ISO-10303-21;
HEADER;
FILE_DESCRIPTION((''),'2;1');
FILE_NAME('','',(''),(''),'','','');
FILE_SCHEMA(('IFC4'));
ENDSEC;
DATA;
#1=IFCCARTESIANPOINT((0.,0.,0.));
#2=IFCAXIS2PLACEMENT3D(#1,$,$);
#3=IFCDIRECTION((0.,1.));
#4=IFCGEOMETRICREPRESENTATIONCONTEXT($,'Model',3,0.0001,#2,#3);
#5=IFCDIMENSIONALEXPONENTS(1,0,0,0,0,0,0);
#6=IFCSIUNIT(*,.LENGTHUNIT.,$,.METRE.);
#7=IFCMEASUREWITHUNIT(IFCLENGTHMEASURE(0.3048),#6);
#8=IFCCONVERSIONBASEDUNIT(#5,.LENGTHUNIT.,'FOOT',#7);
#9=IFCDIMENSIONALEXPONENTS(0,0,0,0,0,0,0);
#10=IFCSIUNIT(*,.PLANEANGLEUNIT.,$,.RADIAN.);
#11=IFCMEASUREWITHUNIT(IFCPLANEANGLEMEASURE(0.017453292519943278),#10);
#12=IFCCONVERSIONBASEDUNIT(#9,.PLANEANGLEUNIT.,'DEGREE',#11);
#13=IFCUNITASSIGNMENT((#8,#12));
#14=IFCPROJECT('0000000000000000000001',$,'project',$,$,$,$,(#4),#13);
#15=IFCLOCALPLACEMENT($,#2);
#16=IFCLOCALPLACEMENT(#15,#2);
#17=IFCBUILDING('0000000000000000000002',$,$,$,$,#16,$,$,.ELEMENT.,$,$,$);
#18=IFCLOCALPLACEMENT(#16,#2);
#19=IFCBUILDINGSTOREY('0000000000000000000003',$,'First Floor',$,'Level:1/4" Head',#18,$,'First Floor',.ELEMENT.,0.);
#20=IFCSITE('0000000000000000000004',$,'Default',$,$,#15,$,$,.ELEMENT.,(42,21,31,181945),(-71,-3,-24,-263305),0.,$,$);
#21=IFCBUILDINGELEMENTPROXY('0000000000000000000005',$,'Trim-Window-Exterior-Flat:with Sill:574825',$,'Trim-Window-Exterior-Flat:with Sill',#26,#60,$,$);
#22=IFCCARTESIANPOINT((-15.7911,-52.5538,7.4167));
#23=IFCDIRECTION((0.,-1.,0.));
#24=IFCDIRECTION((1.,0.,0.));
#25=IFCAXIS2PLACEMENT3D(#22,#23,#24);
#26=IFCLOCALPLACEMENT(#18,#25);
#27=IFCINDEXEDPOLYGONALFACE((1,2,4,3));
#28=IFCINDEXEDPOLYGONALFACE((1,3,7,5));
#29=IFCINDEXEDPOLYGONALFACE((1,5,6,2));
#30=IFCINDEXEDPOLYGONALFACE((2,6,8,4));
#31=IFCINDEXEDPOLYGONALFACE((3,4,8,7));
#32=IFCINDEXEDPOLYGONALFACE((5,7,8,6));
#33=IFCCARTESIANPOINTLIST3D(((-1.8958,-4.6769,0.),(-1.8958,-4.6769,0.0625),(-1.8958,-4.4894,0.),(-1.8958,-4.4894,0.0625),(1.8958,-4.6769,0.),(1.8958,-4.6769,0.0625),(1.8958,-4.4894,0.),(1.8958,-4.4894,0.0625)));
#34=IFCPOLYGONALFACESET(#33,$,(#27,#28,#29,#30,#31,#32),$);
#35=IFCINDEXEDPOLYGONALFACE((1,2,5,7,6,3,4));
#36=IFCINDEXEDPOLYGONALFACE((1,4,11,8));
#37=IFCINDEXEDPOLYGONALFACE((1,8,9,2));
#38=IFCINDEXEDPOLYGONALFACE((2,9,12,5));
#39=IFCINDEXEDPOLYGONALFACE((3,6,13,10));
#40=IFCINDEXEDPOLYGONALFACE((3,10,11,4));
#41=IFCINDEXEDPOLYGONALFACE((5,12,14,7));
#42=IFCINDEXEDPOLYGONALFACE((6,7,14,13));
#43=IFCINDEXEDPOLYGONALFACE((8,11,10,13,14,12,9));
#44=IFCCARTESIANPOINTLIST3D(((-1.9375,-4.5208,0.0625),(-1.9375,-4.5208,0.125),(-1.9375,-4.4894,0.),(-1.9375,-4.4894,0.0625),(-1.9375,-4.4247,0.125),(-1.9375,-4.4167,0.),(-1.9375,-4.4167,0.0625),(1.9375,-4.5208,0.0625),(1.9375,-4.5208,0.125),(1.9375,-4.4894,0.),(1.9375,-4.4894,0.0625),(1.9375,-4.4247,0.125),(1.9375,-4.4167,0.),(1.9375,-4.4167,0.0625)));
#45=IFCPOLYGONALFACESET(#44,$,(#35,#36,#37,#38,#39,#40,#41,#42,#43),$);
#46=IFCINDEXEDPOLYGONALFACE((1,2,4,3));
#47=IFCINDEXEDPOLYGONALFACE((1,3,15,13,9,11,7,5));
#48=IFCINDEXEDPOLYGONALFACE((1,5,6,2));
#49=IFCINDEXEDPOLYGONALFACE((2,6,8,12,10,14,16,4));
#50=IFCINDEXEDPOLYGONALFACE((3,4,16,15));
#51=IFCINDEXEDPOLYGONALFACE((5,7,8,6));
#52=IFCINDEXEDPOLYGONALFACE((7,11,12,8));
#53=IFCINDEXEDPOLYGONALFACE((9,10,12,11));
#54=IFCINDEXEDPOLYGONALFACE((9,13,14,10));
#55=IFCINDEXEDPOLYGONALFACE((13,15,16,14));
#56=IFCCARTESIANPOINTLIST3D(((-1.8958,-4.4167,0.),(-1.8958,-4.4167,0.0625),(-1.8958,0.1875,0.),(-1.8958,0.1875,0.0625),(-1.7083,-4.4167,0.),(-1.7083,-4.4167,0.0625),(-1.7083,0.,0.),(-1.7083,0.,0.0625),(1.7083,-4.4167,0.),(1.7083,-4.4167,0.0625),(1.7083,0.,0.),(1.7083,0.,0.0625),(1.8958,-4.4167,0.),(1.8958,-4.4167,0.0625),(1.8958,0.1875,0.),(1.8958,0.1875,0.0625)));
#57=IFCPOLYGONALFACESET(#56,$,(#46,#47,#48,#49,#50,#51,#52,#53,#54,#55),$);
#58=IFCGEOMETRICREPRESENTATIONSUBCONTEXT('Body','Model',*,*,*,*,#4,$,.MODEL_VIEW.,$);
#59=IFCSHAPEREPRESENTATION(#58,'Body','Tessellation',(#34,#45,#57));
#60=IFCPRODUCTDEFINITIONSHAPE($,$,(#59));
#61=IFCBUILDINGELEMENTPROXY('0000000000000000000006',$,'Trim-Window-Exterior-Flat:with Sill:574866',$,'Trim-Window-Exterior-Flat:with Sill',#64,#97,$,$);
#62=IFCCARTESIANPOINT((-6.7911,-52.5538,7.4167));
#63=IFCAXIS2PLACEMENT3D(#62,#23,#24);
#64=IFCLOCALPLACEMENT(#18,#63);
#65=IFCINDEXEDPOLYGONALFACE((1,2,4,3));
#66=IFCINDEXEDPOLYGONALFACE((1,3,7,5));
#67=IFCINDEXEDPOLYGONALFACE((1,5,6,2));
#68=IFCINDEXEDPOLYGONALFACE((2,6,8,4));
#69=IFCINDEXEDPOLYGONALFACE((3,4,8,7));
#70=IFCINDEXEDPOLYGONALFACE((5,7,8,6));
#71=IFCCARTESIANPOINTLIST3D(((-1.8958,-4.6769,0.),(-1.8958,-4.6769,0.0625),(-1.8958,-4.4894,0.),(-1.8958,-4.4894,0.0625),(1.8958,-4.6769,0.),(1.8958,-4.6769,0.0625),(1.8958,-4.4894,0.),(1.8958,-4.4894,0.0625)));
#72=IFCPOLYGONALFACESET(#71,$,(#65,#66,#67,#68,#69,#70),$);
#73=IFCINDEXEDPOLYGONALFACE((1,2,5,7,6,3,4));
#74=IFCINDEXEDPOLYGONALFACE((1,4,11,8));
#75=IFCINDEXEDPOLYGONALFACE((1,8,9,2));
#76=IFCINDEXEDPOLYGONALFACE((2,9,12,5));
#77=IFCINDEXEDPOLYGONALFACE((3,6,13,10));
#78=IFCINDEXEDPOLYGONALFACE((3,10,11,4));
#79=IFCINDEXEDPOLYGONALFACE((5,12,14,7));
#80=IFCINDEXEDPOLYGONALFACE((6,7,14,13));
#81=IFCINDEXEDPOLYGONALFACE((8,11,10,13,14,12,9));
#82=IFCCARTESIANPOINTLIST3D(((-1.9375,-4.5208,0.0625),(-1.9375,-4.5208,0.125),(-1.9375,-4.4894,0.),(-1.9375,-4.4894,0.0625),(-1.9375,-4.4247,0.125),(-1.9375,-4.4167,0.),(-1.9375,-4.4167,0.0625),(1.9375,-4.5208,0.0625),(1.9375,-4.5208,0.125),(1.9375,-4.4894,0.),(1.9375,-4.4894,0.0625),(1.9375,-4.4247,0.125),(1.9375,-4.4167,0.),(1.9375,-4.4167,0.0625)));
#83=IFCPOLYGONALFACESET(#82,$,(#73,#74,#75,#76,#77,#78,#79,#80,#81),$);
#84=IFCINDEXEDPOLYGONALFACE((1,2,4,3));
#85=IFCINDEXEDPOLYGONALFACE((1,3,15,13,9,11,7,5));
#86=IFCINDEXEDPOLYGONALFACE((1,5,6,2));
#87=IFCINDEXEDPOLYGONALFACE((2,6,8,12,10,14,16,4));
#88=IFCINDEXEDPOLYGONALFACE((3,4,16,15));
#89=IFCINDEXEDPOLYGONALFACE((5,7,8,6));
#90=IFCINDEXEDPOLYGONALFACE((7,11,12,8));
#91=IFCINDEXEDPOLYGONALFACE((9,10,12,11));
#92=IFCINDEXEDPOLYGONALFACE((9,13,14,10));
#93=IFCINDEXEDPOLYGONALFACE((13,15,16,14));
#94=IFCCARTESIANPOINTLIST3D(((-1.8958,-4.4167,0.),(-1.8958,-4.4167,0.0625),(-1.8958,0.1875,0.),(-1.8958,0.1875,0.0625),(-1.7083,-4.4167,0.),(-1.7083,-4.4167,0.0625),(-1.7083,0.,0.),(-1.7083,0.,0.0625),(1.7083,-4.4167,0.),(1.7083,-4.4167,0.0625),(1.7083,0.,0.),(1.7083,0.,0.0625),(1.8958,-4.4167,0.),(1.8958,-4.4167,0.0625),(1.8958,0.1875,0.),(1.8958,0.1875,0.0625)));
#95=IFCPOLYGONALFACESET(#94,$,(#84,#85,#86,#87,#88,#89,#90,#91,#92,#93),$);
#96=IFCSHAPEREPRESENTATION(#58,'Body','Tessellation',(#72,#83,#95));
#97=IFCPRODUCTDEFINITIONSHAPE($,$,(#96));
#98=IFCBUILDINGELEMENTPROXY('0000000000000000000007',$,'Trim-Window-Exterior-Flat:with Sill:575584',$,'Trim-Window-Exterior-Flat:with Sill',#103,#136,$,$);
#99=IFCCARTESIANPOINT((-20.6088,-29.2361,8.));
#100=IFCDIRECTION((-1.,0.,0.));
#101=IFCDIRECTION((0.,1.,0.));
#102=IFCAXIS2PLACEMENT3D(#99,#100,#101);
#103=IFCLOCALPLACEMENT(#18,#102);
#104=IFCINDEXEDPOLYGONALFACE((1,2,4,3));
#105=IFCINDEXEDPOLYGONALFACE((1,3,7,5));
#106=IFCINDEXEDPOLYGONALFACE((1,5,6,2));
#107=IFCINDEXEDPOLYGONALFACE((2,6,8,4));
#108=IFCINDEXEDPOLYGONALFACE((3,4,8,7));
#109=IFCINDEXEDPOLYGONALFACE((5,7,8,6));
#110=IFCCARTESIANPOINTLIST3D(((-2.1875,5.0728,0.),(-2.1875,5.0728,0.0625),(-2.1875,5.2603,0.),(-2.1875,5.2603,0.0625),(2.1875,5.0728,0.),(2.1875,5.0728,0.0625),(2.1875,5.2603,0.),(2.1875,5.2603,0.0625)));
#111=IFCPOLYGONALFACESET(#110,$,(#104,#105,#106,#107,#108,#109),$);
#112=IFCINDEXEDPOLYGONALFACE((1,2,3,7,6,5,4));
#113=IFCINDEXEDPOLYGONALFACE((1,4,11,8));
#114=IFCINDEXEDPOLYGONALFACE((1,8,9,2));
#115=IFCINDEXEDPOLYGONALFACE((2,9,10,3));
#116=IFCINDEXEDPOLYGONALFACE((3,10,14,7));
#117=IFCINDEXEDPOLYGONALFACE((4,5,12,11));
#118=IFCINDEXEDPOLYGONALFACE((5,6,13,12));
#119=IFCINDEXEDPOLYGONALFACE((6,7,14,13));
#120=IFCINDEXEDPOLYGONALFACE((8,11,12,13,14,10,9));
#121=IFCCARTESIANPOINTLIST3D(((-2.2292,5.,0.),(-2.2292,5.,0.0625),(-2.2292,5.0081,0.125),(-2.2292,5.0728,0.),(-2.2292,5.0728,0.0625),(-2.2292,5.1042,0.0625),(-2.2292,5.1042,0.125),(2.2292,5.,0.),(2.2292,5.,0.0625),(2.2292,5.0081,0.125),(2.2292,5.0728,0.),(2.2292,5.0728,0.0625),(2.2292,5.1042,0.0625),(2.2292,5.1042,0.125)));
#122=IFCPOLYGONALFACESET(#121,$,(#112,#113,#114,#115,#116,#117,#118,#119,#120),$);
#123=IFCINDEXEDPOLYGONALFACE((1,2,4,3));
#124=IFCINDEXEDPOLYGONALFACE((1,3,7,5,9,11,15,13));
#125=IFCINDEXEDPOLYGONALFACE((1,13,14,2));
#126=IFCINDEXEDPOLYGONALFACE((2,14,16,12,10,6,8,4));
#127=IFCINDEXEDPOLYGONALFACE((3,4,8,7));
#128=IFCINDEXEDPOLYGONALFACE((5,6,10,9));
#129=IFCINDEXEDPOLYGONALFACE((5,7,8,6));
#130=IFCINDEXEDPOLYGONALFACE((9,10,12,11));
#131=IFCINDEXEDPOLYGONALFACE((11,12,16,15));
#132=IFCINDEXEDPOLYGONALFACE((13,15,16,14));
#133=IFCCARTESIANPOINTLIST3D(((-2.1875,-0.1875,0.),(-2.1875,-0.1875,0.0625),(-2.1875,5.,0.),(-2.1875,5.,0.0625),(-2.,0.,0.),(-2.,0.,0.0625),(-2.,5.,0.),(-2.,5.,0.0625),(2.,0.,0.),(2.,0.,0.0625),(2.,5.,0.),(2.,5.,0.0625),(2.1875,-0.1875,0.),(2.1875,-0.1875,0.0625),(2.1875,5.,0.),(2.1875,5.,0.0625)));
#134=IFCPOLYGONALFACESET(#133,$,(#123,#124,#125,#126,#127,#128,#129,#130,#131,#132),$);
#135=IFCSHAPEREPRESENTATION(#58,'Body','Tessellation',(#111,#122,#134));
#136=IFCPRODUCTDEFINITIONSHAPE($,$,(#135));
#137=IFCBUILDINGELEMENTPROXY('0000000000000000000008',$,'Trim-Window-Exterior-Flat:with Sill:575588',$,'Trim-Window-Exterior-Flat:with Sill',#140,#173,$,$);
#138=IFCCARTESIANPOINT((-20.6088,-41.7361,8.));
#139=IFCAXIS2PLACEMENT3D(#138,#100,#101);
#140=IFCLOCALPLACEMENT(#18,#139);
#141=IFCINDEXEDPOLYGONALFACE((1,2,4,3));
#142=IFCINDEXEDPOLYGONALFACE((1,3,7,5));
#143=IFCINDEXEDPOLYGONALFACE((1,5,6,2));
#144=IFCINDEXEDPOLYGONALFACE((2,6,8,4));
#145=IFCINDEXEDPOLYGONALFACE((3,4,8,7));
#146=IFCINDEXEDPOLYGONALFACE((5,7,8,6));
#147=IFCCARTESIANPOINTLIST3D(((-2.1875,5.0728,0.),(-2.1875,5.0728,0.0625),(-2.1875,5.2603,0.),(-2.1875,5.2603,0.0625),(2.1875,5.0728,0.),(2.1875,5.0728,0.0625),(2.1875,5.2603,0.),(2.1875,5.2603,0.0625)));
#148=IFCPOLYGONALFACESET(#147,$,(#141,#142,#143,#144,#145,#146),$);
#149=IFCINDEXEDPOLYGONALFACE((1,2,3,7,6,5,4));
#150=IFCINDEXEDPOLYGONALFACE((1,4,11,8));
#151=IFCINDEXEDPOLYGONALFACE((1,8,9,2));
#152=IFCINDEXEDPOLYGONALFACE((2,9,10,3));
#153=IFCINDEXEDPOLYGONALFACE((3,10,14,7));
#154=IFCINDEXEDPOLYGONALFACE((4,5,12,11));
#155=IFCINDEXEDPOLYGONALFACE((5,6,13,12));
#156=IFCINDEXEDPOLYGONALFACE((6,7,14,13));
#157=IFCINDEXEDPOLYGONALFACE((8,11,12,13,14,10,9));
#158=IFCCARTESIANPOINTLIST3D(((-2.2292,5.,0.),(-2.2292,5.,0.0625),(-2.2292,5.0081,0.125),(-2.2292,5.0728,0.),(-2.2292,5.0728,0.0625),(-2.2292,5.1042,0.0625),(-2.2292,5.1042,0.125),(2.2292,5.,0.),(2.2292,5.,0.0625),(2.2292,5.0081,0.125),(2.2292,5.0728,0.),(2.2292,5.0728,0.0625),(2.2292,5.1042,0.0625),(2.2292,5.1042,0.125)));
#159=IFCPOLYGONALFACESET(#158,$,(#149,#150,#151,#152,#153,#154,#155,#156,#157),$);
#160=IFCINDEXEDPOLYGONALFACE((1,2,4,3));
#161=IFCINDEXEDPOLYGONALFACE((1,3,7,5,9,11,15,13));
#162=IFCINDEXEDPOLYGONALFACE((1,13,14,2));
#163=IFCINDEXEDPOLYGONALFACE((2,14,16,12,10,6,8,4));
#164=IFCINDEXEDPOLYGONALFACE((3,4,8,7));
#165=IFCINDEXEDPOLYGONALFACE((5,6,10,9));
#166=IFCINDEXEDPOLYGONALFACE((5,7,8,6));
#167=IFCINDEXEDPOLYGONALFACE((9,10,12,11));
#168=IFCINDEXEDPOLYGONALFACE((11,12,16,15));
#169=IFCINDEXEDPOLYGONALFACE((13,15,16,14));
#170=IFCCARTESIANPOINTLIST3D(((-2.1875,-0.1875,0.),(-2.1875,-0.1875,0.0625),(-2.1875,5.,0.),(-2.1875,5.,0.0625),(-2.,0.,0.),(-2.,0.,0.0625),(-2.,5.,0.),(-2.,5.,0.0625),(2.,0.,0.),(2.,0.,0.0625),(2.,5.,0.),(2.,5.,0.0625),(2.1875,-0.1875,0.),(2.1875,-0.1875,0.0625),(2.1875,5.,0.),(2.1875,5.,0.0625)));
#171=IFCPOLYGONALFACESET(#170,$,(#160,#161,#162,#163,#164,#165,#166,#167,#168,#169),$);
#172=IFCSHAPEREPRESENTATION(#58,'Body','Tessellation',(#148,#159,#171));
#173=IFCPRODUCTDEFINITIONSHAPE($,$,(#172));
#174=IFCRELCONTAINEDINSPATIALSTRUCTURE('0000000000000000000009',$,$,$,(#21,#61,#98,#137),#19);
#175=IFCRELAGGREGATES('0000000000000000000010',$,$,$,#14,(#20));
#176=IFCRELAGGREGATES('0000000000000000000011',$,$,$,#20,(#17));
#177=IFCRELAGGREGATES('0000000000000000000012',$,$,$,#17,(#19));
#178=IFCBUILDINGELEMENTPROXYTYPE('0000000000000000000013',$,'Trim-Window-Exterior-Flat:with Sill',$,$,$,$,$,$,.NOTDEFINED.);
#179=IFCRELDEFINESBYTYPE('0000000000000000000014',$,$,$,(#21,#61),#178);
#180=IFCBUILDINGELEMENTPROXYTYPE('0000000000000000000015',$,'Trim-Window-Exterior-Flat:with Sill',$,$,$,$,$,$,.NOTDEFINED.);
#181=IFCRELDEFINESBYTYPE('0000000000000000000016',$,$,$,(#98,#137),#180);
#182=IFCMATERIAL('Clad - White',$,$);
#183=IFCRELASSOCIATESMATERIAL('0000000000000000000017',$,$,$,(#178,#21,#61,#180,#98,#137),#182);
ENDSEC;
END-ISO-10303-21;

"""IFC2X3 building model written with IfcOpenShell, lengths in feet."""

from ifc_helpers import new_model, entity, si_unit, converted_unit, direction, frame, frame_2d, origin, place, context, subcontext, project, spatial, polyline, rectangle, outline, extrude, source, transform, mapped, material, type_object, type_shapes, element, save


model = new_model("IFC2X3")

# Units and contexts
model_context = context("Model", 3, precision=0.0001, world=origin(), true_north=direction((0.0, 1.0)))
body_context = subcontext(model_context, "Body", "Model", "MODEL_VIEW")
ifc_project = project(units=[converted_unit("LENGTHUNIT", "FOOT", entity("IfcLengthMeasure", 0.3048), si_unit("LENGTHUNIT", "METRE"), dimensions=[1, 0, 0, 0, 0, 0, 0]), converted_unit("PLANEANGLEUNIT", "DEGREE", entity("IfcPlaneAngleMeasure", 0.017453292519943278), si_unit("PLANEANGLEUNIT", "RADIAN"), dimensions=[0, 0, 0, 0, 0, 0, 0])], contexts=[model_context])

# Site, building, storey
site_placement = place(None, origin())
site = spatial("IfcSite", under=ifc_project, at=site_placement, Name="Default", CompositionType="ELEMENT", RefLatitude=(42, 21, 31, 181945), RefLongitude=(-71, -3, -24, -263305), RefElevation=0.0)
building_placement = place(site_placement, origin())
building = spatial("IfcBuilding", under=site, at=building_placement, CompositionType="ELEMENT")
storey_placement = place(building_placement, origin())
storey = spatial("IfcBuildingStorey", under=building, at=storey_placement, Name="First Floor", ObjectType="Level:1/4\" Head", LongName="First Floor", CompositionType="ELEMENT", Elevation=0.0)

# Building element proxies
ifc_material_1 = material(Name="Clad - White")
building_element_proxy_type_1 = type_object("IfcBuildingElementProxyType", Name="Trim-Window-Exterior-Flat:with Sill", PredefinedType="NOTDEFINED", material=ifc_material_1)
shared_shape_1 = source(origin(), body_context, "Body", "SweptSolid", [
    extrude(rectangle(XDim=3.7917, YDim=0.1875, at=frame_2d((0.0, 0.0), x_axis=(1.0, 0.0))), frame((0.0, -4.5832, 0.0), z_axis=(0.0, 0.0, 1.0), x_axis=(-1.0, 0.0, 0.0)), (0.0, 0.0, 1.0), 0.0625),
    extrude(outline(polyline([(-0.0625, -0.0525), (0.0, -0.0525), (0.0, -0.0211), (0.0625, -0.0211), (0.0625, 0.0517), (0.0, 0.0517), (-0.0625, 0.0436), (-0.0625, -0.0525)])), frame((-1.9375, -4.4684, 0.0625), z_axis=(1.0, 0.0, 0.0), x_axis=(0.0, 0.0, -1.0)), (0.0, 0.0, 1.0), 3.875),
    extrude(outline(polyline([(-2.349, -1.8958), (2.2552, -1.8958), (2.2552, -1.7083), (-2.1615, -1.7083), (-2.1615, 1.7083), (2.2552, 1.7083), (2.2552, 1.8958), (-2.349, 1.8958), (-2.349, -1.8958)])), frame((0.0, -2.1615, 0.0), z_axis=(0.0, 0.0, 1.0), x_axis=(0.0, -1.0, 0.0)), (0.0, 0.0, 1.0), 0.0625),
])
type_shapes(building_element_proxy_type_1, [shared_shape_1])
for number, where, z_axis, x_axis, name in (
    (1, (-15.7911, -52.5538, 7.4167), (0.0, -1.0, 0.0), (1.0, 0.0, 0.0), "Trim-Window-Exterior-Flat:with Sill:574825"),
    (2, (-6.7911, -52.5538, 7.4167), (0.0, -1.0, 0.0), (1.0, 0.0, 0.0), "Trim-Window-Exterior-Flat:with Sill:574866"),
):
    element("IfcBuildingElementProxy", number, at=place(storey_placement, frame(where, z_axis=z_axis, x_axis=x_axis)), inside=storey, type_object=building_element_proxy_type_1, material=ifc_material_1, Name=name, ObjectType="Trim-Window-Exterior-Flat:with Sill", context=body_context, shape_type="MappedRepresentation", body=[
        mapped(shared_shape_1, transform((0.0, 0.0, 0.0), scale=1.0)),
    ])
building_element_proxy_type_2 = type_object("IfcBuildingElementProxyType", Name="Trim-Window-Exterior-Flat:with Sill", PredefinedType="NOTDEFINED", material=ifc_material_1)
shared_shape_2 = source(origin(), body_context, "Body", "SweptSolid", [
    extrude(rectangle(XDim=0.1875, YDim=4.375, at=frame_2d((0.0, 0.0), x_axis=(1.0, 0.0))), frame((0.0, 5.1665, 0.0), z_axis=(0.0, 0.0, 1.0), x_axis=(0.0, 1.0, 0.0)), (0.0, 0.0, 1.0), 0.0625),
    extrude(outline(polyline([(-0.0525, -0.0625), (0.0436, -0.0625), (0.0517, 0.0), (0.0517, 0.0625), (-0.0211, 0.0625), (-0.0211, 0.0), (-0.0525, 0.0), (-0.0525, -0.0625)])), frame((-2.2292, 5.0517, 0.0625), z_axis=(1.0, 0.0, 0.0), x_axis=(0.0, -1.0, 0.0)), (0.0, 0.0, 1.0), 4.4583),
    extrude(outline(polyline([(-2.1875, -2.6406), (2.1875, -2.6406), (2.1875, 2.5469), (2.0, 2.5469), (2.0, -2.4531), (-2.0, -2.4531), (-2.0, 2.5469), (-2.1875, 2.5469), (-2.1875, -2.6406)])), frame((0.0, 2.4531, 0.0)), (0.0, 0.0, 1.0), 0.0625),
])
type_shapes(building_element_proxy_type_2, [shared_shape_2])
for number, where, z_axis, x_axis, name in (
    (3, (-20.6088, -29.2361, 8.0), (-1.0, 0.0, 0.0), (0.0, 1.0, 0.0), "Trim-Window-Exterior-Flat:with Sill:575584"),
    (4, (-20.6088, -41.7361, 8.0), (-1.0, 0.0, 0.0), (0.0, 1.0, 0.0), "Trim-Window-Exterior-Flat:with Sill:575588"),
):
    element("IfcBuildingElementProxy", number, at=place(storey_placement, frame(where, z_axis=z_axis, x_axis=x_axis)), inside=storey, type_object=building_element_proxy_type_2, material=ifc_material_1, Name=name, ObjectType="Trim-Window-Exterior-Flat:with Sill", context=body_context, shape_type="MappedRepresentation", body=[
        mapped(shared_shape_2, transform((0.0, 0.0, 0.0), scale=1.0)),
    ])

save(model, "model.ifc")
